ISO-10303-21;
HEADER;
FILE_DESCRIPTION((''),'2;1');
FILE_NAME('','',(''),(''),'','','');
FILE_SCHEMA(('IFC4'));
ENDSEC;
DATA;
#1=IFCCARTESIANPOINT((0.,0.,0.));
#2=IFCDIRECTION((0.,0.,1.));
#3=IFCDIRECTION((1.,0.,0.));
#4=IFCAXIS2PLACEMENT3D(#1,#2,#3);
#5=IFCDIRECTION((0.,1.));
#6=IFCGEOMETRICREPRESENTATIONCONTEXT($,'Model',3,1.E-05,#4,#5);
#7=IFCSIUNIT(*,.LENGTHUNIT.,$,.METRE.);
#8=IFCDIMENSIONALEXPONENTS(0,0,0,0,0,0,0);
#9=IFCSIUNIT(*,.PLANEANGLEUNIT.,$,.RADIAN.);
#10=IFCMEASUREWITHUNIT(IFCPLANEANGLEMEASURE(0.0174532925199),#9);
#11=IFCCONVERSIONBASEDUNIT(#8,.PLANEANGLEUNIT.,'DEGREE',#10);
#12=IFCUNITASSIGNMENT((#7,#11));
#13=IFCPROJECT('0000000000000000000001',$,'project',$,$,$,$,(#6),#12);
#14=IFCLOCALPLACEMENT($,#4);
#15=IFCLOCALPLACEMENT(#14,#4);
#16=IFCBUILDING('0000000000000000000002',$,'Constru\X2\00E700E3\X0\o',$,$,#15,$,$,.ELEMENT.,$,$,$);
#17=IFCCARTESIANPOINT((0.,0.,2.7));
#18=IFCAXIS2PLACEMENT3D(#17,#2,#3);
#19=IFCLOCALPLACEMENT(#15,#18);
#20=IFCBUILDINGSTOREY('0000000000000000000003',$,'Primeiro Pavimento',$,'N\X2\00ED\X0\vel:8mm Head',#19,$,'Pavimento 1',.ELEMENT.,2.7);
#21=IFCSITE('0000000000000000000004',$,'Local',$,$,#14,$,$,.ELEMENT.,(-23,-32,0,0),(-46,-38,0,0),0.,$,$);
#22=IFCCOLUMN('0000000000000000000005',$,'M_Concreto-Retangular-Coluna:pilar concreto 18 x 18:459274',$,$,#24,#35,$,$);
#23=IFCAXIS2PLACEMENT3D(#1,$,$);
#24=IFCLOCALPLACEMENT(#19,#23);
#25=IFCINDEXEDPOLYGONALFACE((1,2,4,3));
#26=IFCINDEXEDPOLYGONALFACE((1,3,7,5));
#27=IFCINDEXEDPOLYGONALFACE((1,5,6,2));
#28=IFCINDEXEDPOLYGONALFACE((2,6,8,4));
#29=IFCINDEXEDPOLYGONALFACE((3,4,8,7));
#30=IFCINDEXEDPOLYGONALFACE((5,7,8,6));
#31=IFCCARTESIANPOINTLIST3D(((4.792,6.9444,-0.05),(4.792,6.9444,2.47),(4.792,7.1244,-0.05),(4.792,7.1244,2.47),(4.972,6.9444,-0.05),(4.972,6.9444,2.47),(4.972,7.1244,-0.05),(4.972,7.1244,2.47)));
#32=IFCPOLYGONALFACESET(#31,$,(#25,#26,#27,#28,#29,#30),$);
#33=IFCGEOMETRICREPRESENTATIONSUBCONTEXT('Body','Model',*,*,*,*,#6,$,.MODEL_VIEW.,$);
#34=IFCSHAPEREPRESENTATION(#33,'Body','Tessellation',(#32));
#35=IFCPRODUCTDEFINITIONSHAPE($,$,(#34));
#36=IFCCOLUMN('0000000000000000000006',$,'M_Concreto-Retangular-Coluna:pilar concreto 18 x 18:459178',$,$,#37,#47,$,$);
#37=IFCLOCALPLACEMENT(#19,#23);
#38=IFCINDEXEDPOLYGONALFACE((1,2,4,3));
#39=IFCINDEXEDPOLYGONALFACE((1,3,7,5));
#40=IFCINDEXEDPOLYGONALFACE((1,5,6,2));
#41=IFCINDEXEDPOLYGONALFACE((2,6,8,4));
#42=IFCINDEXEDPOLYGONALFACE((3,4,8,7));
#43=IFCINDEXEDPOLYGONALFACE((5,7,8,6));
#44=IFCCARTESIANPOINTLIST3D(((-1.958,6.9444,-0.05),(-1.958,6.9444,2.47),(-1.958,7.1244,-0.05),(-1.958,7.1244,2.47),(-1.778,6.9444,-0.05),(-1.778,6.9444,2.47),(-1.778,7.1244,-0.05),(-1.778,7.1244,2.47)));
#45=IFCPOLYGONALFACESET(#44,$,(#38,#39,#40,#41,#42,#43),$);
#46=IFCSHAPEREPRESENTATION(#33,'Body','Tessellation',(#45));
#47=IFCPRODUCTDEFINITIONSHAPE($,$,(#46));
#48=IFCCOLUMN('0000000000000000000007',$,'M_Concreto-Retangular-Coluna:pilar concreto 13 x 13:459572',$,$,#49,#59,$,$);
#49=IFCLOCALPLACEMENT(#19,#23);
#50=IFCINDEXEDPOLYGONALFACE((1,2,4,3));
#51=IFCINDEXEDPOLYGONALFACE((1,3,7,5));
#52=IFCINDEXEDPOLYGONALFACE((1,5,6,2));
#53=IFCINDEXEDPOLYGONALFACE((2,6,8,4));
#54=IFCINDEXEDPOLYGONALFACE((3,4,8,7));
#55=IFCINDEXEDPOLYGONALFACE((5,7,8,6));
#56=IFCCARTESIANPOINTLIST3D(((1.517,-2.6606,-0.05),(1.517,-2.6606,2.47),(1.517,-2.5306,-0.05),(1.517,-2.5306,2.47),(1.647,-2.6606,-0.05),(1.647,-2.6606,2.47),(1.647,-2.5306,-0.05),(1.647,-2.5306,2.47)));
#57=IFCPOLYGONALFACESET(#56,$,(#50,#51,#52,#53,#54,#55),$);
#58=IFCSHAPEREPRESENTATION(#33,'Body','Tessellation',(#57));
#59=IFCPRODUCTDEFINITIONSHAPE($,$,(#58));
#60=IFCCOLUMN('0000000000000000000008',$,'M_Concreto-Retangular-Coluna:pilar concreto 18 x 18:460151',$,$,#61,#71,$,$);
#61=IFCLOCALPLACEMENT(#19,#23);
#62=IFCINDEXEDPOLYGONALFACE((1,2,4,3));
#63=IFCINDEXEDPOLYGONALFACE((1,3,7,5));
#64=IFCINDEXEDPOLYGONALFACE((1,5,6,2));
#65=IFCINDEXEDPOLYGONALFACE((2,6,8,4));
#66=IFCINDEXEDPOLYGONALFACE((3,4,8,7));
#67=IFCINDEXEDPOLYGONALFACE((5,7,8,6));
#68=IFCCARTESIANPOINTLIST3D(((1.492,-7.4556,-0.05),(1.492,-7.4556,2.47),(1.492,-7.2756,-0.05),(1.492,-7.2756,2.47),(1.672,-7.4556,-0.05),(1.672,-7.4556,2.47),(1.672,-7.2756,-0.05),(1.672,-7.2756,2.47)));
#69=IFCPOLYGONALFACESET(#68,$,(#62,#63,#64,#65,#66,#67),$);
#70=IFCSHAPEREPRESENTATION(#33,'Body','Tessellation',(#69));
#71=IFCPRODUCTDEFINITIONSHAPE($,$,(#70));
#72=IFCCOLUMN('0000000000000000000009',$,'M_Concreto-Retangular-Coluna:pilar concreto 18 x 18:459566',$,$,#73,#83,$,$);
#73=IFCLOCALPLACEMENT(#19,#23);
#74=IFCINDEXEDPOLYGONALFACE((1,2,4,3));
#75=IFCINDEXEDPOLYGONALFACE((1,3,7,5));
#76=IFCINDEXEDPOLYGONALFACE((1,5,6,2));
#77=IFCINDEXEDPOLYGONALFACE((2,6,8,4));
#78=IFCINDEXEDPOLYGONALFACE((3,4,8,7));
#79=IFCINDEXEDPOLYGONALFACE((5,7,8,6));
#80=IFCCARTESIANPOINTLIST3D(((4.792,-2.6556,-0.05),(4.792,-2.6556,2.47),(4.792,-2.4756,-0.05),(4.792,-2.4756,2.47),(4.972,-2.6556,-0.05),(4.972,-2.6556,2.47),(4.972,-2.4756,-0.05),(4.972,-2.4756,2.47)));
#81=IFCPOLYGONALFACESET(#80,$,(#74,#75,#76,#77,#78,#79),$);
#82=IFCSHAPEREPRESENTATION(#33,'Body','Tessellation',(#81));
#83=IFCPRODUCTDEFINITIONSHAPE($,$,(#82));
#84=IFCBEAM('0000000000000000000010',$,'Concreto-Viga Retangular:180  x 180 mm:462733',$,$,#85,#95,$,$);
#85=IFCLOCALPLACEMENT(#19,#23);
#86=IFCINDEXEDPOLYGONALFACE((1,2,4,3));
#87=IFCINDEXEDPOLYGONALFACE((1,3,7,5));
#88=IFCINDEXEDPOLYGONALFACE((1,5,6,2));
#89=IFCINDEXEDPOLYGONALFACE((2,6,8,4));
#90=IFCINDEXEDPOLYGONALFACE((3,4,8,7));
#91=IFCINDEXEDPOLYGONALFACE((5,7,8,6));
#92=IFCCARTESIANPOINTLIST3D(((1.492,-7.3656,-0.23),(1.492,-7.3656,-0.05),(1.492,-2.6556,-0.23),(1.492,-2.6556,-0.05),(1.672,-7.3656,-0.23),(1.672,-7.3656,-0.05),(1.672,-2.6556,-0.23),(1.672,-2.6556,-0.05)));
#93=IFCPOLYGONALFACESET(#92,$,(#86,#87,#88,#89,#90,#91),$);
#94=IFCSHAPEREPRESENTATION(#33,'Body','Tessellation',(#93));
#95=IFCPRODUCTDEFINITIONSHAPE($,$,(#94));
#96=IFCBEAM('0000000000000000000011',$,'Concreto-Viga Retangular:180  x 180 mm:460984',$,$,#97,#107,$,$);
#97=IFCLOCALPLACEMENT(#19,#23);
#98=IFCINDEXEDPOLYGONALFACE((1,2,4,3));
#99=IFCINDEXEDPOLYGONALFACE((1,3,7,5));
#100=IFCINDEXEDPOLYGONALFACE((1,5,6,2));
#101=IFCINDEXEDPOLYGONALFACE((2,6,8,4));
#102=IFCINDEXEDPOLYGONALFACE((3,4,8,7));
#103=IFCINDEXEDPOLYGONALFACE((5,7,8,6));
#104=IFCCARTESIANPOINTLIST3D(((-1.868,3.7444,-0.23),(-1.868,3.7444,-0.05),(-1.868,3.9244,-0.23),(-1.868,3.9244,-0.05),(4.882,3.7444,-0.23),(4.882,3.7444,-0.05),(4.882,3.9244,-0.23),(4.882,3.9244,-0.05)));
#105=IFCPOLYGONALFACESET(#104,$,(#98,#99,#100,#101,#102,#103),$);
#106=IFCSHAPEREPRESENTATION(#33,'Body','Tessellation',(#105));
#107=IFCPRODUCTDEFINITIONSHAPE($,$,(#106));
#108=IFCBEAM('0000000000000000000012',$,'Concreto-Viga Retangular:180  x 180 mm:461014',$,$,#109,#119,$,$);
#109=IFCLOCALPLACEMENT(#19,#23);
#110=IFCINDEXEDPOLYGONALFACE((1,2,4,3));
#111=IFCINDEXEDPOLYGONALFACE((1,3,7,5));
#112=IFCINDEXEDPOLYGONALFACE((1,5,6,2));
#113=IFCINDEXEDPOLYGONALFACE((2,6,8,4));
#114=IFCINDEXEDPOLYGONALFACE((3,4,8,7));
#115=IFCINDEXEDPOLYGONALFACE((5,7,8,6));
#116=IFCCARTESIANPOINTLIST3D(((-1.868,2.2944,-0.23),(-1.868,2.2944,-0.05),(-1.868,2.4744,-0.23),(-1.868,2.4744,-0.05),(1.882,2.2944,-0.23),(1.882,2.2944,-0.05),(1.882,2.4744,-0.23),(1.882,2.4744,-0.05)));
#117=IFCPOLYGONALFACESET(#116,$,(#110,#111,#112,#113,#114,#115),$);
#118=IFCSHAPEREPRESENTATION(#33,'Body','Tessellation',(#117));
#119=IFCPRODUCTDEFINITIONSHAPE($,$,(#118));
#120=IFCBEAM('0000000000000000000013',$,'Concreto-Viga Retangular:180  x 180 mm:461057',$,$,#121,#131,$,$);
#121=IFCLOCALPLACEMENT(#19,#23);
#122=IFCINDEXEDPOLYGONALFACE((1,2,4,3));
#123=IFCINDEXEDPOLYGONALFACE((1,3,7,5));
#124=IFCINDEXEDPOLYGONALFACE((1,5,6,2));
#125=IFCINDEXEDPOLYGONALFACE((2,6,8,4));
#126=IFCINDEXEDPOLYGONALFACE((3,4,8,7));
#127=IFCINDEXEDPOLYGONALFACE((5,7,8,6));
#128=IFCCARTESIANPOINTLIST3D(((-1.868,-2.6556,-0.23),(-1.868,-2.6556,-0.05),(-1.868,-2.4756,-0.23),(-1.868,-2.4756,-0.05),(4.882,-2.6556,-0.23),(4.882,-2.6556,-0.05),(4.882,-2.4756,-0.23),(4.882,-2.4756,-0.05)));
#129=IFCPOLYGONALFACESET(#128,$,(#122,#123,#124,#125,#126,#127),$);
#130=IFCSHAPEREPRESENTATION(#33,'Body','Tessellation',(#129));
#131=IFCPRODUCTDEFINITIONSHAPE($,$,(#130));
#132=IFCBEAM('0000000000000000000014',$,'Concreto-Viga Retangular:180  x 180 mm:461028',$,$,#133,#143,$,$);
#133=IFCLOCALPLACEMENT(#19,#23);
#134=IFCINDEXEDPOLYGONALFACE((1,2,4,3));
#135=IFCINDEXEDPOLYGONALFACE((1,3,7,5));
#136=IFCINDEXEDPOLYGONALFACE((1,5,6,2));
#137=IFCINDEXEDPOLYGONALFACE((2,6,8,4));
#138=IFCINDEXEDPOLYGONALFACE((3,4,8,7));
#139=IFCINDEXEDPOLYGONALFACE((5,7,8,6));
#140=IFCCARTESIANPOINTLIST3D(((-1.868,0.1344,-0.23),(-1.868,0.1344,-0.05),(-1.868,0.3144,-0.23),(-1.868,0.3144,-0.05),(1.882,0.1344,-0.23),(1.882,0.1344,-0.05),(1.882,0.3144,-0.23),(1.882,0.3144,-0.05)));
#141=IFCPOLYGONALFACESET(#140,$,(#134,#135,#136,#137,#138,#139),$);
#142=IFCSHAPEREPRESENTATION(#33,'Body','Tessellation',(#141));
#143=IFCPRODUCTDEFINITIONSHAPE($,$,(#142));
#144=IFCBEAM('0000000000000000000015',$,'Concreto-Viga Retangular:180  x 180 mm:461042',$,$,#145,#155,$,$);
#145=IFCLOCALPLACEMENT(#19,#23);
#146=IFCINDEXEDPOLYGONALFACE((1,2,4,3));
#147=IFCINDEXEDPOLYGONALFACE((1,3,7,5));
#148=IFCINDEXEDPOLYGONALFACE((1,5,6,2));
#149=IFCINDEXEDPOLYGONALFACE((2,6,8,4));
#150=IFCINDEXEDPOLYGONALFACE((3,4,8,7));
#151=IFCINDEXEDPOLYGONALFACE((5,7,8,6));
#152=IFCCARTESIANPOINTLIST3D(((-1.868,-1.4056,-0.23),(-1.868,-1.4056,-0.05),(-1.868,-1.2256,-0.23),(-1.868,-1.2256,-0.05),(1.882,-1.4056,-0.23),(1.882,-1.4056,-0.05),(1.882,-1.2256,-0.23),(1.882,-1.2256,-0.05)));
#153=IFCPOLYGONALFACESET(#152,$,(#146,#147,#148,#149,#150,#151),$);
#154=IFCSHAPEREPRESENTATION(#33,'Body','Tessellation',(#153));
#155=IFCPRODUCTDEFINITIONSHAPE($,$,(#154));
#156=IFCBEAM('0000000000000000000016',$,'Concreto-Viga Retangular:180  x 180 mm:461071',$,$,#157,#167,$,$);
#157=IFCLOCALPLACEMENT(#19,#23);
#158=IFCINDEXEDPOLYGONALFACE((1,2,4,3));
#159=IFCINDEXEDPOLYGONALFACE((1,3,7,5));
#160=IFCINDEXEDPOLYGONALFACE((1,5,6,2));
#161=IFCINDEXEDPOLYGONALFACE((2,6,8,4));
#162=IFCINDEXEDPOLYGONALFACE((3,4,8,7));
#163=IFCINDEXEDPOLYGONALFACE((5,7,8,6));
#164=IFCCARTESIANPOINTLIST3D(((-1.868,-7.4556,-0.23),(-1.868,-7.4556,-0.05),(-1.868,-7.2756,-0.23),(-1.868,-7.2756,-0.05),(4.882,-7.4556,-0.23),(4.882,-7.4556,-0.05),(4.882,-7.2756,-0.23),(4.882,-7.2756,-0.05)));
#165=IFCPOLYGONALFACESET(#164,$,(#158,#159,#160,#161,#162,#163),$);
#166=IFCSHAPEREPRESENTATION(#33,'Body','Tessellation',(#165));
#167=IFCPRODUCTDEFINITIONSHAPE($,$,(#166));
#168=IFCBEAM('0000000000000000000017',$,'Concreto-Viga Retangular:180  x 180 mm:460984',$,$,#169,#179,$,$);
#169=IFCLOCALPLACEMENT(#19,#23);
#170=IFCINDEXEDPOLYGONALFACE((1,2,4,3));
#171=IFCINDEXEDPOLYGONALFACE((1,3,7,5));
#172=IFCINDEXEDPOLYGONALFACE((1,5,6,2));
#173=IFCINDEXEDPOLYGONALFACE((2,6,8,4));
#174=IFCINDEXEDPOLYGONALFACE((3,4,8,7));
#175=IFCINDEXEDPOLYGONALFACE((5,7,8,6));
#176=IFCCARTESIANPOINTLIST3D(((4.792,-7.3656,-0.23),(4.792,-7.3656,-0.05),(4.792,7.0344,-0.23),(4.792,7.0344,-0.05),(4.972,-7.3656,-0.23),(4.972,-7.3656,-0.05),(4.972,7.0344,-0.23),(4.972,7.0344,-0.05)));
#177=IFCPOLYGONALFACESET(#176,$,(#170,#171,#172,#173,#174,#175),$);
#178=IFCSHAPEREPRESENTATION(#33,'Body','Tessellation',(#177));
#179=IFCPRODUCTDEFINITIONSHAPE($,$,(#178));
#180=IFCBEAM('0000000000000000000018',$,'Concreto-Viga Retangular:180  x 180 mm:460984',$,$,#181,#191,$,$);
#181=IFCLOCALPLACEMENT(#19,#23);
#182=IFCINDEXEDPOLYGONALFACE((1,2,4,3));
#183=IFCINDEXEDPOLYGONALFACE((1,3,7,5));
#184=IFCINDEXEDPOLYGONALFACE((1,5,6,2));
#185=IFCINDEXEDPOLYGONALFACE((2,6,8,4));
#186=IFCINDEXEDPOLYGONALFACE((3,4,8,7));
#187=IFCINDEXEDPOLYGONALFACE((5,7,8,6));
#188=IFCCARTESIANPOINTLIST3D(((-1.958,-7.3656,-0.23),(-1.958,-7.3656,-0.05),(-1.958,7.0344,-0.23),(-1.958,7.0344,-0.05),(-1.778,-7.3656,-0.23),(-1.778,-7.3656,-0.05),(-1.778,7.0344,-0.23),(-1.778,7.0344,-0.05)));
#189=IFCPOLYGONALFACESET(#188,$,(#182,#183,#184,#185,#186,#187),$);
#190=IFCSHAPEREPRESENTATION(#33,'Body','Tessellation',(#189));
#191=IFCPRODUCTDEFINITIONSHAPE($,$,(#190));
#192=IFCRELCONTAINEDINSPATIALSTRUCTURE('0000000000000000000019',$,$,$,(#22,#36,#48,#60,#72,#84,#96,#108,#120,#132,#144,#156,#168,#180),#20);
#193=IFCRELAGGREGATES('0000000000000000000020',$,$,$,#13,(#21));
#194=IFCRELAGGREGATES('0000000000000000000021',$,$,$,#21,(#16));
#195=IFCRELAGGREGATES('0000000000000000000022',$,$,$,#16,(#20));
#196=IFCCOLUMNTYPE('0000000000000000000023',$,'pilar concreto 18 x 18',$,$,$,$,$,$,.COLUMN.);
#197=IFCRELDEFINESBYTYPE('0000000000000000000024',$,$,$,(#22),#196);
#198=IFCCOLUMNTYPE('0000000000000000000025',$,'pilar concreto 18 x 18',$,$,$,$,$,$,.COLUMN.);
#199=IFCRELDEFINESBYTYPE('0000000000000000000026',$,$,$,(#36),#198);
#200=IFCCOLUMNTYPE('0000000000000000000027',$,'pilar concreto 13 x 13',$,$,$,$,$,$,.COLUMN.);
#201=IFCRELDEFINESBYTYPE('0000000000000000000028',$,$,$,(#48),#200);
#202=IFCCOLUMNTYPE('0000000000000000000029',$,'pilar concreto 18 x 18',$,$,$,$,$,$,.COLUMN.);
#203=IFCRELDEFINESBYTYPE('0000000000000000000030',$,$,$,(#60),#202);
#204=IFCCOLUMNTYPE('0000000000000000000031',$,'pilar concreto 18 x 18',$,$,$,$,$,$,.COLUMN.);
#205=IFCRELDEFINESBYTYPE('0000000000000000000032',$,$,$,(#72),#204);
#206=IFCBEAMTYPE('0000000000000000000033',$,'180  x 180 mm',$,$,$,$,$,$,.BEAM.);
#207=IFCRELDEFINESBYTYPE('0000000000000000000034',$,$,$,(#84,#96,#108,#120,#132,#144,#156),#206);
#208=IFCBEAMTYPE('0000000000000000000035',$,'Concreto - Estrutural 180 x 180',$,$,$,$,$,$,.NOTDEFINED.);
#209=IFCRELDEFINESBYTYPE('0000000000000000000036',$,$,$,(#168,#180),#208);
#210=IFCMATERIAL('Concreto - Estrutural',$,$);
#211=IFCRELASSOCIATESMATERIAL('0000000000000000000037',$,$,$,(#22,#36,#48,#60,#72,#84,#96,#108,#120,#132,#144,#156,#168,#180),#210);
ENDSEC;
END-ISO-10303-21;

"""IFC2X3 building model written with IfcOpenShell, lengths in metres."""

from ifc_helpers import new_model, entity, si_unit, converted_unit, direction, frame, frame_2d, origin_with_axes, origin_2d_with_axis, place, context, subcontext, project, spatial, rectangle, extrude, material, type_object, element, save


model = new_model("IFC2X3")

# Units and contexts
model_context = context("Model", 3, precision=1e-05, world=origin_with_axes(), true_north=direction((0.0, 1.0)))
body_context = subcontext(model_context, "Body", "Model", "MODEL_VIEW")
ifc_project = project(units=[si_unit("LENGTHUNIT", "METRE"), converted_unit("PLANEANGLEUNIT", "DEGREE", entity("IfcPlaneAngleMeasure", 0.0174532925199), si_unit("PLANEANGLEUNIT", "RADIAN"), dimensions=[0, 0, 0, 0, 0, 0, 0])], contexts=[model_context])

# Site, building, storey
site_placement = place(None, origin_with_axes())
site = spatial("IfcSite", under=ifc_project, at=site_placement, Name="Local", CompositionType="ELEMENT", RefLatitude=(-23, -32, 0, 0), RefLongitude=(-46, -38, 0, 0), RefElevation=0.0)
building_placement = place(site_placement, origin_with_axes())
building = spatial("IfcBuilding", under=site, at=building_placement, Name="Construção", CompositionType="ELEMENT")
storey_placement = place(building_placement, frame((0.0, 0.0, 2.7), z_axis=(0.0, 0.0, 1.0), x_axis=(1.0, 0.0, 0.0)))
storey = spatial("IfcBuildingStorey", under=building, at=storey_placement, Name="Primeiro Pavimento", ObjectType="Nível:8mm Head", LongName="Pavimento 1", CompositionType="ELEMENT", Elevation=2.7)

# Columns
ifc_material = material(Name="Concreto - Estrutural")
column_type_1 = type_object("IfcColumnType", Name="pilar concreto 18 x 18", PredefinedType="COLUMN")
column_1_placement = place(storey_placement, frame((4.882, 7.0344, -0.05), z_axis=(0.0, 0.0, 1.0), x_axis=(0.0, -1.0, 0.0)))
element("IfcColumn", 1, at=column_1_placement, inside=storey, type_object=column_type_1, material=ifc_material, Name="M_Concreto-Retangular-Coluna:pilar concreto 18 x 18:459274", context=body_context, shape_type="SweptSolid", body=[
    extrude(rectangle(XDim=0.18, YDim=0.18, at=origin_2d_with_axis()), origin_with_axes(), (0.0, 0.0, 1.0), 2.52),
])
column_type_2 = type_object("IfcColumnType", Name="pilar concreto 18 x 18", PredefinedType="COLUMN")
column_2_placement = place(storey_placement, frame((-1.868, 7.0344, -0.05), z_axis=(0.0, 0.0, 1.0), x_axis=(0.0, -1.0, 0.0)))
element("IfcColumn", 2, at=column_2_placement, inside=storey, type_object=column_type_2, material=ifc_material, Name="M_Concreto-Retangular-Coluna:pilar concreto 18 x 18:459178", context=body_context, shape_type="SweptSolid", body=[
    extrude(rectangle(XDim=0.18, YDim=0.18, at=origin_2d_with_axis()), origin_with_axes(), (0.0, 0.0, 1.0), 2.52),
])
column_type_3 = type_object("IfcColumnType", Name="pilar concreto 13 x 13", PredefinedType="COLUMN")
column_3_placement = place(storey_placement, frame((1.582, -2.5956, -0.05), z_axis=(0.0, 0.0, 1.0), x_axis=(0.0, -1.0, 0.0)))
element("IfcColumn", 3, at=column_3_placement, inside=storey, type_object=column_type_3, material=ifc_material, Name="M_Concreto-Retangular-Coluna:pilar concreto 13 x 13:459572", context=body_context, shape_type="SweptSolid", body=[
    extrude(rectangle(XDim=0.13, YDim=0.13, at=origin_2d_with_axis()), origin_with_axes(), (0.0, 0.0, 1.0), 2.52),
])
column_type_4 = type_object("IfcColumnType", Name="pilar concreto 18 x 18", PredefinedType="COLUMN")
column_4_placement = place(storey_placement, frame((1.582, -7.3656, -0.05), z_axis=(0.0, 0.0, 1.0), x_axis=(0.0, -1.0, 0.0)))
element("IfcColumn", 4, at=column_4_placement, inside=storey, type_object=column_type_4, material=ifc_material, Name="M_Concreto-Retangular-Coluna:pilar concreto 18 x 18:460151", context=body_context, shape_type="SweptSolid", body=[
    extrude(rectangle(XDim=0.18, YDim=0.18, at=origin_2d_with_axis()), origin_with_axes(), (0.0, 0.0, 1.0), 2.52),
])
column_type_5 = type_object("IfcColumnType", Name="pilar concreto 18 x 18", PredefinedType="COLUMN")
column_5_placement = place(storey_placement, frame((4.882, -2.5656, -0.05), z_axis=(0.0, 0.0, 1.0), x_axis=(0.0, -1.0, 0.0)))
element("IfcColumn", 5, at=column_5_placement, inside=storey, type_object=column_type_5, material=ifc_material, Name="M_Concreto-Retangular-Coluna:pilar concreto 18 x 18:459566", context=body_context, shape_type="SweptSolid", body=[
    extrude(rectangle(XDim=0.18, YDim=0.18, at=origin_2d_with_axis()), origin_with_axes(), (0.0, 0.0, 1.0), 2.52),
])

# Beams
beam_type_1 = type_object("IfcBeamType", Name="180  x 180 mm", PredefinedType="BEAM")
beam_1_placement = place(storey_placement, frame((1.582, -7.3656, -0.05), z_axis=(0.0, 0.0, 1.0), x_axis=(1.0, 0.0, 0.0)))
element("IfcBeam", 6, at=beam_1_placement, inside=storey, type_object=beam_type_1, material=ifc_material, Name="Concreto-Viga Retangular:180  x 180 mm:462733", context=body_context, shape_type="SweptSolid", body=[
    extrude(rectangle(XDim=0.18, YDim=0.18, at=frame_2d((-0.09, 0.0), x_axis=(1.0, 0.0))), frame((0.0, 0.0, 0.0), z_axis=(0.0, 1.0, 0.0), x_axis=(0.0, 0.0, 1.0)), (0.0, 0.0, 1.0), 4.71),
])
beam_2_placement = place(storey_placement, frame((4.882, 3.8344, -0.05), z_axis=(0.0, 0.0, 1.0), x_axis=(0.0, 1.0, 0.0)))
element("IfcBeam", 7, at=beam_2_placement, inside=storey, type_object=beam_type_1, material=ifc_material, Name="Concreto-Viga Retangular:180  x 180 mm:460984", context=body_context, shape_type="SweptSolid", body=[
    extrude(rectangle(XDim=0.18, YDim=0.18, at=frame_2d((-0.09, 0.0), x_axis=(1.0, 0.0))), frame((0.0, 0.0, 0.0), z_axis=(0.0, 1.0, 0.0), x_axis=(0.0, 0.0, 1.0)), (0.0, 0.0, 1.0), 6.75),
])
beam_3_placement = place(storey_placement, frame((1.882, 2.3844, -0.05), z_axis=(0.0, 0.0, 1.0), x_axis=(0.0, 1.0, 0.0)))
element("IfcBeam", 8, at=beam_3_placement, inside=storey, type_object=beam_type_1, material=ifc_material, Name="Concreto-Viga Retangular:180  x 180 mm:461014", context=body_context, shape_type="SweptSolid", body=[
    extrude(rectangle(XDim=0.18, YDim=0.18, at=frame_2d((-0.09, 0.0), x_axis=(1.0, 0.0))), frame((0.0, 0.0, 0.0), z_axis=(0.0, 1.0, 0.0), x_axis=(0.0, 0.0, 1.0)), (0.0, 0.0, 1.0), 3.75),
])
beam_4_placement = place(storey_placement, frame((4.882, -2.5656, -0.05), z_axis=(0.0, 0.0, 1.0), x_axis=(0.0, 1.0, 0.0)))
element("IfcBeam", 9, at=beam_4_placement, inside=storey, type_object=beam_type_1, material=ifc_material, Name="Concreto-Viga Retangular:180  x 180 mm:461057", context=body_context, shape_type="SweptSolid", body=[
    extrude(rectangle(XDim=0.18, YDim=0.18, at=frame_2d((-0.09, 0.0), x_axis=(1.0, 0.0))), frame((0.0, 0.0, 0.0), z_axis=(0.0, 1.0, 0.0), x_axis=(0.0, 0.0, 1.0)), (0.0, 0.0, 1.0), 6.75),
])
for number, where, z_axis, x_axis, name in (
    (10, (1.882, 0.2244, -0.05), (0.0, 0.0, 1.0), (0.0, 1.0, 0.0), "Concreto-Viga Retangular:180  x 180 mm:461028"),
    (11, (1.882, -1.3156, -0.05), (0.0, 0.0, 1.0), (0.0, 1.0, 0.0), "Concreto-Viga Retangular:180  x 180 mm:461042"),
):
    element("IfcBeam", number, at=place(storey_placement, frame(where, z_axis=z_axis, x_axis=x_axis)), inside=storey, type_object=beam_type_1, material=ifc_material, Name=name, context=body_context, shape_type="SweptSolid", body=[
        extrude(rectangle(XDim=0.18, YDim=0.18, at=frame_2d((-0.09, 0.0), x_axis=(1.0, 0.0))), frame((0.0, 0.0, 0.0), z_axis=(0.0, 1.0, 0.0), x_axis=(0.0, 0.0, 1.0)), (0.0, 0.0, 1.0), 3.75),
    ])
beam_5_placement = place(storey_placement, frame((4.882, -7.3656, -0.05), z_axis=(0.0, 0.0, 1.0), x_axis=(0.0, 1.0, 0.0)))
element("IfcBeam", 12, at=beam_5_placement, inside=storey, type_object=beam_type_1, material=ifc_material, Name="Concreto-Viga Retangular:180  x 180 mm:461071", context=body_context, shape_type="SweptSolid", body=[
    extrude(rectangle(XDim=0.18, YDim=0.18, at=frame_2d((-0.09, 0.0), x_axis=(1.0, 0.0))), frame((0.0, 0.0, 0.0), z_axis=(0.0, 1.0, 0.0), x_axis=(0.0, 0.0, 1.0)), (0.0, 0.0, 1.0), 6.75),
])
beam_type_2 = type_object("IfcBeamType", Name="Concreto - Estrutural 180 x 180", PredefinedType="NOTDEFINED")
for number, where, z_axis, x_axis, name in (
    (13, (4.882, -7.3656, -0.05), (0.0, 0.0, 1.0), (1.0, 0.0, 0.0), "Concreto-Viga Retangular:180  x 180 mm:460984"),
    (14, (-1.868, -7.3656, -0.05), (0.0, 0.0, 1.0), (1.0, 0.0, 0.0), "Concreto-Viga Retangular:180  x 180 mm:460984"),
):
    element("IfcBeam", number, at=place(storey_placement, frame(where, z_axis=z_axis, x_axis=x_axis)), inside=storey, type_object=beam_type_2, material=ifc_material, Name=name, context=body_context, shape_type="SweptSolid", body=[
        extrude(rectangle(XDim=0.18, YDim=0.18, at=frame_2d((-0.09, 0.0), x_axis=(1.0, 0.0))), frame((0.0, 0.0, 0.0), z_axis=(0.0, 1.0, 0.0), x_axis=(0.0, 0.0, 1.0)), (0.0, 0.0, 1.0), 14.4),
    ])

save(model, "model.ifc")
